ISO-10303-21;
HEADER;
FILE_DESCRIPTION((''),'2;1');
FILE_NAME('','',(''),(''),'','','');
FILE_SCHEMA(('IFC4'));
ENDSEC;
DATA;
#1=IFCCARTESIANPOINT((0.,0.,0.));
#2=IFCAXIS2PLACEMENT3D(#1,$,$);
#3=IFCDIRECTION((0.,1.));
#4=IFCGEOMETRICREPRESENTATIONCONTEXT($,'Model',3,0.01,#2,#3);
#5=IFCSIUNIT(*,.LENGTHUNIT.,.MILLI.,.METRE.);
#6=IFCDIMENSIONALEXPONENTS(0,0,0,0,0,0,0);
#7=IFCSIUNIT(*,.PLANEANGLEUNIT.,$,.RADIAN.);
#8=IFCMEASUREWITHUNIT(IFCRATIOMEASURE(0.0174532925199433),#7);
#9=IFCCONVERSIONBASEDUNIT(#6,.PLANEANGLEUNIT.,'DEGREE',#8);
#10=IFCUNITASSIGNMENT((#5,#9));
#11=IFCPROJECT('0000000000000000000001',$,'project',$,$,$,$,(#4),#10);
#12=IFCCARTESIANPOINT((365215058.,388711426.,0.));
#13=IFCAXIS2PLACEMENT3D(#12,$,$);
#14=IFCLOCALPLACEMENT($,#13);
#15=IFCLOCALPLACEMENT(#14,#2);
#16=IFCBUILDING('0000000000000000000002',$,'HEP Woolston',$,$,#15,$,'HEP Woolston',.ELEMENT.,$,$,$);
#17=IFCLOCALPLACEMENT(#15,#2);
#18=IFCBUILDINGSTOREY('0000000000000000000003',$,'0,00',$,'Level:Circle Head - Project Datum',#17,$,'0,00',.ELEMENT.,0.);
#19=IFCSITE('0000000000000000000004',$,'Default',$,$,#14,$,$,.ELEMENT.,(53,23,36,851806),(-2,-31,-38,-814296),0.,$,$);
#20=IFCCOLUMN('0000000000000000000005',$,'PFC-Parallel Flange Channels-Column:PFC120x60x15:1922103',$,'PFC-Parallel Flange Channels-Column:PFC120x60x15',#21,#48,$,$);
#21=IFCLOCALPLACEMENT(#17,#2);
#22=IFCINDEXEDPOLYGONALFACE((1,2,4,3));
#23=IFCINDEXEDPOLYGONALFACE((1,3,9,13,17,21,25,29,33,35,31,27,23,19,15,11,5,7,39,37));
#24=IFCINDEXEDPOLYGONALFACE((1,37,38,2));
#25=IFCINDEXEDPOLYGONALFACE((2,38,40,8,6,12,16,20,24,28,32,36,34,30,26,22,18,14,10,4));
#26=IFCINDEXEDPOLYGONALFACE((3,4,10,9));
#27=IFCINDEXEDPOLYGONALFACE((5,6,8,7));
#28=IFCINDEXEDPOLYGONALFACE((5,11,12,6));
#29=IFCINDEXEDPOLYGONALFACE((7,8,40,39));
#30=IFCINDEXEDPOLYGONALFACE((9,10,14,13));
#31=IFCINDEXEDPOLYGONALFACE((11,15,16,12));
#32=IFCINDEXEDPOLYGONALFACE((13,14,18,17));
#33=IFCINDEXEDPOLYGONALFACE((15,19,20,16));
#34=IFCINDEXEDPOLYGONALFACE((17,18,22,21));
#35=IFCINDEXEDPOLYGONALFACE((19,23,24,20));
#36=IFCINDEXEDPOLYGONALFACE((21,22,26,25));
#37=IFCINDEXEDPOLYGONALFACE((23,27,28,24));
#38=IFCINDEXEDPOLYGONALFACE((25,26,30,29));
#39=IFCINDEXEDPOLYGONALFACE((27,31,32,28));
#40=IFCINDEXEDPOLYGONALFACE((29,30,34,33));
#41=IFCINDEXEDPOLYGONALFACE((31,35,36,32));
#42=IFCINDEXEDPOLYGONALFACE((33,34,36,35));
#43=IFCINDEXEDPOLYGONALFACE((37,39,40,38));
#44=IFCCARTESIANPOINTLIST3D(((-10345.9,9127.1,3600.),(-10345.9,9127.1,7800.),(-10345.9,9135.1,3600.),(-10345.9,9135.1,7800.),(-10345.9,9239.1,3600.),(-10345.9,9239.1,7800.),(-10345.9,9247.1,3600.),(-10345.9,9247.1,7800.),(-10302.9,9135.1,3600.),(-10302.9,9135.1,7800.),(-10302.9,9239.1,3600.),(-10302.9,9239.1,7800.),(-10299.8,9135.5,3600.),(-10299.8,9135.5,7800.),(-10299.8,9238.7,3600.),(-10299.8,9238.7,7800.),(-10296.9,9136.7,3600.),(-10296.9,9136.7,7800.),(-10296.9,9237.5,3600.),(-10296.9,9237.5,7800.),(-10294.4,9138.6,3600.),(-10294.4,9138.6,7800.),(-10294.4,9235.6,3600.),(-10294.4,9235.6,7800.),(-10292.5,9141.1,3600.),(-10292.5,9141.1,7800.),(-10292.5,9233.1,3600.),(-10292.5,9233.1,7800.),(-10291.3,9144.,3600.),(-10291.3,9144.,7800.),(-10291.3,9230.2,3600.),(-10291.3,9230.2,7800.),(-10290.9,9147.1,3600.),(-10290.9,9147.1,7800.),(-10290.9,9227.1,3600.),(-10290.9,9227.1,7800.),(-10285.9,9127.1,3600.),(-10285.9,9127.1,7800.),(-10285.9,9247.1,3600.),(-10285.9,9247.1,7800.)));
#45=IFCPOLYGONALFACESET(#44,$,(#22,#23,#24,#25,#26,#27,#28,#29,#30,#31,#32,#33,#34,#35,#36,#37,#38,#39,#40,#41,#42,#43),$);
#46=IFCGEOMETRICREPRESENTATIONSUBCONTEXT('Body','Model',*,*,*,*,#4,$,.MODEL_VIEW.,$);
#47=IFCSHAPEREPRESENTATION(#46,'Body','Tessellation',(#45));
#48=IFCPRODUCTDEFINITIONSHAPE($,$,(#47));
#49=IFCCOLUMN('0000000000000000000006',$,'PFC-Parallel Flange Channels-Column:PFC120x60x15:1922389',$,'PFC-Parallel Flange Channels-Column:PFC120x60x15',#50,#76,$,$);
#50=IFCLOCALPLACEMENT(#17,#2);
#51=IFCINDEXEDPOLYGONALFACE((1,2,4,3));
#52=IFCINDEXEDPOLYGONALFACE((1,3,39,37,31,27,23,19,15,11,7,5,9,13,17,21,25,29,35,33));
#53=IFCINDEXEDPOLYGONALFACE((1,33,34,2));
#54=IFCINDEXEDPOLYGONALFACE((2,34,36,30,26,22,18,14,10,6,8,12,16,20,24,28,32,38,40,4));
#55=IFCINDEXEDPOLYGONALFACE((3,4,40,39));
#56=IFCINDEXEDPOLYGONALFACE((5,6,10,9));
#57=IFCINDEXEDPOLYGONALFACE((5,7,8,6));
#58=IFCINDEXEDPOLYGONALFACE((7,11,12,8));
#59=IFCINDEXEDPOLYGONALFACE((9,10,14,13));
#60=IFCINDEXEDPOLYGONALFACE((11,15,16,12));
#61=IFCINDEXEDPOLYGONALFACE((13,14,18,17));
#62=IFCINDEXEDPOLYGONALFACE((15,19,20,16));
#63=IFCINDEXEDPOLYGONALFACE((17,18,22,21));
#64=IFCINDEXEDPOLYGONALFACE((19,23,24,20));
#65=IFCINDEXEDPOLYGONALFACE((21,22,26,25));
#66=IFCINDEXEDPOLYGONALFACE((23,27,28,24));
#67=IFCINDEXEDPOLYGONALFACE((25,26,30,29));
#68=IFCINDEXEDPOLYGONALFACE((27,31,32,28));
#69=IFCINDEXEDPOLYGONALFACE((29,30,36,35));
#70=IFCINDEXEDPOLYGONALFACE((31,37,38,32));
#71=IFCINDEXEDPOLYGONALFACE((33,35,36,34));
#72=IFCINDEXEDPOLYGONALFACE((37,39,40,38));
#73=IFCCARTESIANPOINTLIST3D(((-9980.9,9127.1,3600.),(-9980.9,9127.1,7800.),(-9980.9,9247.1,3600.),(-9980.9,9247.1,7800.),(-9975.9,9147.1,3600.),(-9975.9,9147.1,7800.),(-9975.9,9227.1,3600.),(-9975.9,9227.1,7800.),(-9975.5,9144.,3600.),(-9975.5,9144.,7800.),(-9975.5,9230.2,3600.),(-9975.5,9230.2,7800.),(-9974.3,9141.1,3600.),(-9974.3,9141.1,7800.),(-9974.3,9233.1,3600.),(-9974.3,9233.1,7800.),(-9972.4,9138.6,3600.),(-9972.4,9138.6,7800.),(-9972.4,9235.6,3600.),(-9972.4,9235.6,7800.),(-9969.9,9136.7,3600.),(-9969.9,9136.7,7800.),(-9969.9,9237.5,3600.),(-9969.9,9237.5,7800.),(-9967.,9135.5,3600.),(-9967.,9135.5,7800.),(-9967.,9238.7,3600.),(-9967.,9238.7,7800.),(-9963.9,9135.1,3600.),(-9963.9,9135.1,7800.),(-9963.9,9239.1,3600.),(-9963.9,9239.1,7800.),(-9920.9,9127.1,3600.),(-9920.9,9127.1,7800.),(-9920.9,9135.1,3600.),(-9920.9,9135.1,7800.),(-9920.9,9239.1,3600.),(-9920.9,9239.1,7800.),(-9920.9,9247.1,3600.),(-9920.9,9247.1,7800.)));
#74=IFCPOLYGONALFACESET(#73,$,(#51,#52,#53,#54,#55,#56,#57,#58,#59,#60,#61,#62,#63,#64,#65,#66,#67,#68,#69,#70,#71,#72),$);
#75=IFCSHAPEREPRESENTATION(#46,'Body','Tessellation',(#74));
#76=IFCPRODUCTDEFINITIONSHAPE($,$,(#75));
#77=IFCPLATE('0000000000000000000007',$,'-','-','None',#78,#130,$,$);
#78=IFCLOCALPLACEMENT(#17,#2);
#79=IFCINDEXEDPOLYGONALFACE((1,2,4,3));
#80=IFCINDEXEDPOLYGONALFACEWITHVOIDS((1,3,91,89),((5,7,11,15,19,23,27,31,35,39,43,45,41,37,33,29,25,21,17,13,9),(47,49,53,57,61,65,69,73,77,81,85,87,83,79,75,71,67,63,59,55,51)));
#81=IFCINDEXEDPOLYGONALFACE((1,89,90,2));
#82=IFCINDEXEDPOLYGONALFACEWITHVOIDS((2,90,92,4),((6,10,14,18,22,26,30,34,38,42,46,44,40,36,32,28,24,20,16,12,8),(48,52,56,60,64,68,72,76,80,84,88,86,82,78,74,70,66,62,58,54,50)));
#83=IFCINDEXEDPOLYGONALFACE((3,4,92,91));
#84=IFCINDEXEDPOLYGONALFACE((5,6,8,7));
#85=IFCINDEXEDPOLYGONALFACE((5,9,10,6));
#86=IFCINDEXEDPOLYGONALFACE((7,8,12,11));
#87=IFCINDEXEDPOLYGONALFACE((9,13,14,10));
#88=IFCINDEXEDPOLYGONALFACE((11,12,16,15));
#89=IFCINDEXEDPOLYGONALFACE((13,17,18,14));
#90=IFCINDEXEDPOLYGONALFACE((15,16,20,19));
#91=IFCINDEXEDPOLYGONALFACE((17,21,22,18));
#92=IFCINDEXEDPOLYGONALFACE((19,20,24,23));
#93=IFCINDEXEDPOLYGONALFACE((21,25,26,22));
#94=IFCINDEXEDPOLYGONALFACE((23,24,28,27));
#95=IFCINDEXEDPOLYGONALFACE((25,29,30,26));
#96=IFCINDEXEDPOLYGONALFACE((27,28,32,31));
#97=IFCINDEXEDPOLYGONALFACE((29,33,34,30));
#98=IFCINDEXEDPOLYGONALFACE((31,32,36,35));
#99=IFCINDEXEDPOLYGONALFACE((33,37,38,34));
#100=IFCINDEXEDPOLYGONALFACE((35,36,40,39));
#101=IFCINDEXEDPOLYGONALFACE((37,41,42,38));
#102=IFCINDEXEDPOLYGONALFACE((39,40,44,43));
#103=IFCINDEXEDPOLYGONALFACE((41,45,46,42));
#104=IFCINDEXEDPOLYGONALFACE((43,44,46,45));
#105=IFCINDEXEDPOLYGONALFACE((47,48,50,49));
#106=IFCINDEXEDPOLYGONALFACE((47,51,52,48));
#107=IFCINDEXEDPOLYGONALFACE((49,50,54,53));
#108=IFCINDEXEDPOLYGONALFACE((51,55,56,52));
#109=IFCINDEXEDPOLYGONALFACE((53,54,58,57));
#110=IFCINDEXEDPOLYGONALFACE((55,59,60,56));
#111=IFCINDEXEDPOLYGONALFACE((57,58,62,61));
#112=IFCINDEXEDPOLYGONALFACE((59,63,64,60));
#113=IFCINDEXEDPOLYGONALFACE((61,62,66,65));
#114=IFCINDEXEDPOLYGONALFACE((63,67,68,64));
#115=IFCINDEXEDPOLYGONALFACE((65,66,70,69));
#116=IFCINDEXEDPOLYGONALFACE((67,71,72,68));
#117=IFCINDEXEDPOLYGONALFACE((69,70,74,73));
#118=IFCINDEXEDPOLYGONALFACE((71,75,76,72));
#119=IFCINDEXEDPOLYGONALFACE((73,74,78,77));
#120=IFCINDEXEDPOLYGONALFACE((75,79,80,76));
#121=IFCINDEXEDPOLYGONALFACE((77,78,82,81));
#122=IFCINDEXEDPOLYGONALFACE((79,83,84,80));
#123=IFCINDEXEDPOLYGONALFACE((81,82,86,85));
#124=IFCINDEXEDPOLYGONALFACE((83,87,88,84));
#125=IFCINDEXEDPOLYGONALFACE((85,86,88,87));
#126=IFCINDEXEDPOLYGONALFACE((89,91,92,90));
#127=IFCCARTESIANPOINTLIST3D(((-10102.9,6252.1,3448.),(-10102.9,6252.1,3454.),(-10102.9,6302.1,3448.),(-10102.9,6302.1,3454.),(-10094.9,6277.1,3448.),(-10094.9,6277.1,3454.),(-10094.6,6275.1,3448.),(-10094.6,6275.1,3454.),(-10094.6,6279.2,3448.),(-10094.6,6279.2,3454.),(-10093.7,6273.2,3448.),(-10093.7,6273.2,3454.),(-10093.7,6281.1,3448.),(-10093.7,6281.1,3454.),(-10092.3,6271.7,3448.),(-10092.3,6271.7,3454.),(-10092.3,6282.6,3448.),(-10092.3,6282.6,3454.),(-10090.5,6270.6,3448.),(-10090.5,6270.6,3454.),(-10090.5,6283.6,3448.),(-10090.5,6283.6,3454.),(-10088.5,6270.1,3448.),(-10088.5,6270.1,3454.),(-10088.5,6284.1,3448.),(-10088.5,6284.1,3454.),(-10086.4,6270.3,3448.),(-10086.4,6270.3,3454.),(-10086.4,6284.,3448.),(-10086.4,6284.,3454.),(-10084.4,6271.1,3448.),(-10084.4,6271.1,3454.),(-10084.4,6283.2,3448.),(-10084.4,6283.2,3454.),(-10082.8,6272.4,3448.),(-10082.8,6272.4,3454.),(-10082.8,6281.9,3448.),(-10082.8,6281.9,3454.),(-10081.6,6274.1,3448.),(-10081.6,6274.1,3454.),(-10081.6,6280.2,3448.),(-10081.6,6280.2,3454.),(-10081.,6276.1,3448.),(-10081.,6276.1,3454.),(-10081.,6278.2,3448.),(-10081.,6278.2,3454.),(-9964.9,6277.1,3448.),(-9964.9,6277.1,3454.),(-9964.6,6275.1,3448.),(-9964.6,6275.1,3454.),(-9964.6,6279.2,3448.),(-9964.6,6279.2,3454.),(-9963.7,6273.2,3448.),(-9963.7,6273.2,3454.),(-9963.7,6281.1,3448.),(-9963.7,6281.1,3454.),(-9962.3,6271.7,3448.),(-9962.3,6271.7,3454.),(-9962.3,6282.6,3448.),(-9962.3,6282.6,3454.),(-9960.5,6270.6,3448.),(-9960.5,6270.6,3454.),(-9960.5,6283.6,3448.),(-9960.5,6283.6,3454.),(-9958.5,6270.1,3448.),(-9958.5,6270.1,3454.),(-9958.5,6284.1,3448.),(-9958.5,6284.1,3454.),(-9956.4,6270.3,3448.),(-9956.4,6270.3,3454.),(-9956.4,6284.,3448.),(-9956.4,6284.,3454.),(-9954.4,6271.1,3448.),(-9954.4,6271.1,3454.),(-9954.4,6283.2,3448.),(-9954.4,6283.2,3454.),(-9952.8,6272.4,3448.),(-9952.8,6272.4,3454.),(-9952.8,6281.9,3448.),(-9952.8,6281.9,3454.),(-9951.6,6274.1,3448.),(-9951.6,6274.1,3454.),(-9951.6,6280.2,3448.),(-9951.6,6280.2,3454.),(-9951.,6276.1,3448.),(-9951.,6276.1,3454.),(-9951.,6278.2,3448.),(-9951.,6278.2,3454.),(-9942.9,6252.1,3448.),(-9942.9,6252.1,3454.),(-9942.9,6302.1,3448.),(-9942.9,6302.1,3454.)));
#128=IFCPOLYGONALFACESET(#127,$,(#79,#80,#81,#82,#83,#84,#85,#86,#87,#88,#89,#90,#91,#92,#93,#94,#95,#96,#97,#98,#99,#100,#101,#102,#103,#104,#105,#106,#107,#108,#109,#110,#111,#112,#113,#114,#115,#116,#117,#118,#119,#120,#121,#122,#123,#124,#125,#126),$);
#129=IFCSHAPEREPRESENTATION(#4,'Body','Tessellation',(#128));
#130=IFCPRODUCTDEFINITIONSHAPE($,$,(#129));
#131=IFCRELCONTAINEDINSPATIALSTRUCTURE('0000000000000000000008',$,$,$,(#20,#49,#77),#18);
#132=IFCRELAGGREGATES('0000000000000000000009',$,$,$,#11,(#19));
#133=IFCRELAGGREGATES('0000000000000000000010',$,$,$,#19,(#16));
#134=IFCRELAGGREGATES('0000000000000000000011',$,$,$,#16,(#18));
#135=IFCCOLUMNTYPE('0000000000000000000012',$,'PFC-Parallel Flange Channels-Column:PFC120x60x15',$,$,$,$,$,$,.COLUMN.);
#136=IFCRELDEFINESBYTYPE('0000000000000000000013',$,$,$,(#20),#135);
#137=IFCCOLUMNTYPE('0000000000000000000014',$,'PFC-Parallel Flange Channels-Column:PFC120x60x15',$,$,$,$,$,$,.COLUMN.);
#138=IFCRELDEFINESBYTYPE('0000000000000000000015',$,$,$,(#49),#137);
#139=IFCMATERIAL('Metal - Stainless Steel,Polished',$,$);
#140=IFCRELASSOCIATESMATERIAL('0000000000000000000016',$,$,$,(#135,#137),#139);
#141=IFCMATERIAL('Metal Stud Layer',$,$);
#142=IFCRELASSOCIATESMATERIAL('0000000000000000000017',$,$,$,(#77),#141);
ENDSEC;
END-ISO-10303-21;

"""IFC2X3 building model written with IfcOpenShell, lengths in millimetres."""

from ifc_helpers import new_model, entity, si_unit, converted_unit, direction, frame, frame_2d, origin, origin_with_axes, place, context, subcontext, project, spatial, polyline, circle_curve, parameter, trimmed, segment, composite_curve, circle, outline, extrude, source, transform, mapped, material, type_object, type_shapes, element, save


model = new_model("IFC2X3")

# Units and contexts
model_context = context("Model", 3, precision=0.01, world=origin(), true_north=direction((0.0, 1.0)))
body_context = subcontext(model_context, "Body", "Model", "MODEL_VIEW")
ifc_project = project(units=[si_unit("LENGTHUNIT", "METRE", prefix="MILLI"), converted_unit("PLANEANGLEUNIT", "DEGREE", entity("IfcRatioMeasure", 0.0174532925199433), si_unit("PLANEANGLEUNIT", "RADIAN"), dimensions=[0, 0, 0, 0, 0, 0, 0])], contexts=[model_context])

# Site, building, storey
site_placement = place(None, frame((365215058.0, 388711426.0, 0.0)))
site = spatial("IfcSite", under=ifc_project, at=site_placement, Name="Default", CompositionType="ELEMENT", RefLatitude=(53, 23, 36, 851806), RefLongitude=(-2, -31, -38, -814296), RefElevation=0.0)
building_placement = place(site_placement, origin())
building = spatial("IfcBuilding", under=site, at=building_placement, Name="HEP Woolston", LongName="HEP Woolston", CompositionType="ELEMENT")
storey_placement = place(building_placement, origin())
storey = spatial("IfcBuildingStorey", under=building, at=storey_placement, Name="0,00", ObjectType="Level:Circle Head - Project Datum", LongName="0,00", CompositionType="ELEMENT", Elevation=0.0)

# Columns
ifc_material_1 = material(Name="Metal - Stainless Steel,Polished")
column_type_1 = type_object("IfcColumnType", Name="PFC-Parallel Flange Channels-Column:PFC120x60x15", PredefinedType="COLUMN", material=ifc_material_1)
shared_shape_1 = source(origin(), body_context, "Body", "SweptSolid", [
    extrude(outline(composite_curve([segment(polyline([(-60.0, -28.4), (60.0, -28.4)]), True, "CONTINUOUS"), segment(polyline([(60.0, -28.4), (60.0, 31.6)]), True, "CONTINUOUS"), segment(polyline([(60.0, 31.6), (52.0, 31.6)]), True, "CONTINUOUS"), segment(polyline([(52.0, 31.6), (52.0, -11.4)]), True, "CONTINUOUS"), segment(trimmed(circle_curve(frame_2d((40.0, -11.4), x_axis=(1.0, 0.0)), 12.0), [parameter(270.0)], [parameter(0.0)], True, "PARAMETER"), False, "CONTINUOUS"), segment(polyline([(40.0, -23.4), (-40.0, -23.4)]), True, "CONTINUOUS"), segment(trimmed(circle_curve(frame_2d((-40.0, -11.4), x_axis=(0.0, -1.0)), 12.0), [parameter(270.0)], [parameter(0.0)], True, "PARAMETER"), False, "CONTINUOUS"), segment(polyline([(-52.0, -11.4), (-52.0, 31.6)]), True, "CONTINUOUS"), segment(polyline([(-52.0, 31.6), (-60.0, 31.6)]), True, "CONTINUOUS"), segment(polyline([(-60.0, 31.6), (-60.0, -28.4)]), True, "CONTINUOUS")], self_intersect=False)), frame((5.4, 0.0, 3600.0), z_axis=(0.0, 0.0, 1.0), x_axis=(0.0, -1.0, 0.0)), (0.0, 0.0, 1.0), 4200.0),
])
type_shapes(column_type_1, [shared_shape_1])
column_1_placement = place(storey_placement, frame((-10308.9, 9187.1, 0.0), z_axis=(0.0, 0.0, 1.0), x_axis=(-1.0, 0.0, 0.0)))
element("IfcColumn", 1, at=column_1_placement, inside=storey, type_object=column_type_1, Name="PFC-Parallel Flange Channels-Column:PFC120x60x15:1922103", ObjectType="PFC-Parallel Flange Channels-Column:PFC120x60x15", context=body_context, shape_type="MappedRepresentation", body=[
    mapped(shared_shape_1, transform((0.0, 0.0, 0.0), scale=1.0)),
])
column_type_2 = type_object("IfcColumnType", Name="PFC-Parallel Flange Channels-Column:PFC120x60x15", PredefinedType="COLUMN", material=ifc_material_1)
shared_shape_2 = source(origin(), body_context, "Body", "SweptSolid", [
    extrude(outline(composite_curve([segment(polyline([(-60.0, -28.4), (60.0, -28.4)]), True, "CONTINUOUS"), segment(polyline([(60.0, -28.4), (60.0, 31.6)]), True, "CONTINUOUS"), segment(polyline([(60.0, 31.6), (52.0, 31.6)]), True, "CONTINUOUS"), segment(polyline([(52.0, 31.6), (52.0, -11.4)]), True, "CONTINUOUS"), segment(trimmed(circle_curve(frame_2d((40.0, -11.4), x_axis=(1.0, 0.0)), 12.0), [parameter(270.0)], [parameter(0.0)], True, "PARAMETER"), False, "CONTINUOUS"), segment(polyline([(40.0, -23.4), (-40.0, -23.4)]), True, "CONTINUOUS"), segment(trimmed(circle_curve(frame_2d((-40.0, -11.4), x_axis=(0.0, -1.0)), 12.0), [parameter(270.0)], [parameter(0.0)], True, "PARAMETER"), False, "CONTINUOUS"), segment(polyline([(-52.0, -11.4), (-52.0, 31.6)]), True, "CONTINUOUS"), segment(polyline([(-52.0, 31.6), (-60.0, 31.6)]), True, "CONTINUOUS"), segment(polyline([(-60.0, 31.6), (-60.0, -28.4)]), True, "CONTINUOUS")], self_intersect=False)), frame((5.4, 0.0, 3600.0), z_axis=(0.0, 0.0, 1.0), x_axis=(0.0, -1.0, 0.0)), (0.0, 0.0, 1.0), 4200.0),
])
type_shapes(column_type_2, [shared_shape_2])
column_2_placement = place(storey_placement, frame((-9957.9, 9187.1, 0.0)))
element("IfcColumn", 2, at=column_2_placement, inside=storey, type_object=column_type_2, Name="PFC-Parallel Flange Channels-Column:PFC120x60x15:1922389", ObjectType="PFC-Parallel Flange Channels-Column:PFC120x60x15", context=body_context, shape_type="MappedRepresentation", body=[
    mapped(shared_shape_2, transform((0.0, 0.0, 0.0), scale=1.0)),
])

# Plate, openings
ifc_material_2 = material(Name="Metal Stud Layer")
plate_1_placement = place(storey_placement, frame((-9942.9, 6252.1, 3454.0), z_axis=(0.0, 0.0, -1.0), x_axis=(-1.0, 0.0, 0.0)))
plate_1 = element("IfcPlate", 3, at=plate_1_placement, inside=storey, material=ifc_material_2, Name="-", Description="-", ObjectType="None", context=model_context, shape_type="SweptSolid", body=[
    extrude(outline(polyline([(160.0, 0.0), (160.0, 50.0), (0.0, 50.0), (0.0, 0.0), (160.0, 0.0)])), origin_with_axes(), (0.0, 0.0, 1.0), 6.0),
])
opening_1_placement = place(plate_1_placement, frame((80.0, 25.0, 6.5), z_axis=(0.0, 0.0, -1.0), x_axis=(1.0, 0.0, 0.0)))
element("IfcOpeningElement", 4, at=opening_1_placement, cuts=plate_1, ObjectType="Opening", context=model_context, shape_type="SweptSolid", body=[
    extrude(circle(Radius=7.0, at=frame_2d((65.0, 0.0), x_axis=(1.0, 0.0))), origin(), (0.0, 0.0, 1.0), 7.0),
])
opening_2_placement = place(plate_1_placement, frame((80.0, 25.0, 6.5), z_axis=(0.0, 0.0, -1.0), x_axis=(1.0, 0.0, 0.0)))
element("IfcOpeningElement", 5, at=opening_2_placement, cuts=plate_1, ObjectType="Opening", context=model_context, shape_type="SweptSolid", body=[
    extrude(circle(Radius=7.0, at=frame_2d((-65.0, 0.0), x_axis=(1.0, 0.0))), origin(), (0.0, 0.0, 1.0), 7.0),
])

save(model, "model.ifc")
